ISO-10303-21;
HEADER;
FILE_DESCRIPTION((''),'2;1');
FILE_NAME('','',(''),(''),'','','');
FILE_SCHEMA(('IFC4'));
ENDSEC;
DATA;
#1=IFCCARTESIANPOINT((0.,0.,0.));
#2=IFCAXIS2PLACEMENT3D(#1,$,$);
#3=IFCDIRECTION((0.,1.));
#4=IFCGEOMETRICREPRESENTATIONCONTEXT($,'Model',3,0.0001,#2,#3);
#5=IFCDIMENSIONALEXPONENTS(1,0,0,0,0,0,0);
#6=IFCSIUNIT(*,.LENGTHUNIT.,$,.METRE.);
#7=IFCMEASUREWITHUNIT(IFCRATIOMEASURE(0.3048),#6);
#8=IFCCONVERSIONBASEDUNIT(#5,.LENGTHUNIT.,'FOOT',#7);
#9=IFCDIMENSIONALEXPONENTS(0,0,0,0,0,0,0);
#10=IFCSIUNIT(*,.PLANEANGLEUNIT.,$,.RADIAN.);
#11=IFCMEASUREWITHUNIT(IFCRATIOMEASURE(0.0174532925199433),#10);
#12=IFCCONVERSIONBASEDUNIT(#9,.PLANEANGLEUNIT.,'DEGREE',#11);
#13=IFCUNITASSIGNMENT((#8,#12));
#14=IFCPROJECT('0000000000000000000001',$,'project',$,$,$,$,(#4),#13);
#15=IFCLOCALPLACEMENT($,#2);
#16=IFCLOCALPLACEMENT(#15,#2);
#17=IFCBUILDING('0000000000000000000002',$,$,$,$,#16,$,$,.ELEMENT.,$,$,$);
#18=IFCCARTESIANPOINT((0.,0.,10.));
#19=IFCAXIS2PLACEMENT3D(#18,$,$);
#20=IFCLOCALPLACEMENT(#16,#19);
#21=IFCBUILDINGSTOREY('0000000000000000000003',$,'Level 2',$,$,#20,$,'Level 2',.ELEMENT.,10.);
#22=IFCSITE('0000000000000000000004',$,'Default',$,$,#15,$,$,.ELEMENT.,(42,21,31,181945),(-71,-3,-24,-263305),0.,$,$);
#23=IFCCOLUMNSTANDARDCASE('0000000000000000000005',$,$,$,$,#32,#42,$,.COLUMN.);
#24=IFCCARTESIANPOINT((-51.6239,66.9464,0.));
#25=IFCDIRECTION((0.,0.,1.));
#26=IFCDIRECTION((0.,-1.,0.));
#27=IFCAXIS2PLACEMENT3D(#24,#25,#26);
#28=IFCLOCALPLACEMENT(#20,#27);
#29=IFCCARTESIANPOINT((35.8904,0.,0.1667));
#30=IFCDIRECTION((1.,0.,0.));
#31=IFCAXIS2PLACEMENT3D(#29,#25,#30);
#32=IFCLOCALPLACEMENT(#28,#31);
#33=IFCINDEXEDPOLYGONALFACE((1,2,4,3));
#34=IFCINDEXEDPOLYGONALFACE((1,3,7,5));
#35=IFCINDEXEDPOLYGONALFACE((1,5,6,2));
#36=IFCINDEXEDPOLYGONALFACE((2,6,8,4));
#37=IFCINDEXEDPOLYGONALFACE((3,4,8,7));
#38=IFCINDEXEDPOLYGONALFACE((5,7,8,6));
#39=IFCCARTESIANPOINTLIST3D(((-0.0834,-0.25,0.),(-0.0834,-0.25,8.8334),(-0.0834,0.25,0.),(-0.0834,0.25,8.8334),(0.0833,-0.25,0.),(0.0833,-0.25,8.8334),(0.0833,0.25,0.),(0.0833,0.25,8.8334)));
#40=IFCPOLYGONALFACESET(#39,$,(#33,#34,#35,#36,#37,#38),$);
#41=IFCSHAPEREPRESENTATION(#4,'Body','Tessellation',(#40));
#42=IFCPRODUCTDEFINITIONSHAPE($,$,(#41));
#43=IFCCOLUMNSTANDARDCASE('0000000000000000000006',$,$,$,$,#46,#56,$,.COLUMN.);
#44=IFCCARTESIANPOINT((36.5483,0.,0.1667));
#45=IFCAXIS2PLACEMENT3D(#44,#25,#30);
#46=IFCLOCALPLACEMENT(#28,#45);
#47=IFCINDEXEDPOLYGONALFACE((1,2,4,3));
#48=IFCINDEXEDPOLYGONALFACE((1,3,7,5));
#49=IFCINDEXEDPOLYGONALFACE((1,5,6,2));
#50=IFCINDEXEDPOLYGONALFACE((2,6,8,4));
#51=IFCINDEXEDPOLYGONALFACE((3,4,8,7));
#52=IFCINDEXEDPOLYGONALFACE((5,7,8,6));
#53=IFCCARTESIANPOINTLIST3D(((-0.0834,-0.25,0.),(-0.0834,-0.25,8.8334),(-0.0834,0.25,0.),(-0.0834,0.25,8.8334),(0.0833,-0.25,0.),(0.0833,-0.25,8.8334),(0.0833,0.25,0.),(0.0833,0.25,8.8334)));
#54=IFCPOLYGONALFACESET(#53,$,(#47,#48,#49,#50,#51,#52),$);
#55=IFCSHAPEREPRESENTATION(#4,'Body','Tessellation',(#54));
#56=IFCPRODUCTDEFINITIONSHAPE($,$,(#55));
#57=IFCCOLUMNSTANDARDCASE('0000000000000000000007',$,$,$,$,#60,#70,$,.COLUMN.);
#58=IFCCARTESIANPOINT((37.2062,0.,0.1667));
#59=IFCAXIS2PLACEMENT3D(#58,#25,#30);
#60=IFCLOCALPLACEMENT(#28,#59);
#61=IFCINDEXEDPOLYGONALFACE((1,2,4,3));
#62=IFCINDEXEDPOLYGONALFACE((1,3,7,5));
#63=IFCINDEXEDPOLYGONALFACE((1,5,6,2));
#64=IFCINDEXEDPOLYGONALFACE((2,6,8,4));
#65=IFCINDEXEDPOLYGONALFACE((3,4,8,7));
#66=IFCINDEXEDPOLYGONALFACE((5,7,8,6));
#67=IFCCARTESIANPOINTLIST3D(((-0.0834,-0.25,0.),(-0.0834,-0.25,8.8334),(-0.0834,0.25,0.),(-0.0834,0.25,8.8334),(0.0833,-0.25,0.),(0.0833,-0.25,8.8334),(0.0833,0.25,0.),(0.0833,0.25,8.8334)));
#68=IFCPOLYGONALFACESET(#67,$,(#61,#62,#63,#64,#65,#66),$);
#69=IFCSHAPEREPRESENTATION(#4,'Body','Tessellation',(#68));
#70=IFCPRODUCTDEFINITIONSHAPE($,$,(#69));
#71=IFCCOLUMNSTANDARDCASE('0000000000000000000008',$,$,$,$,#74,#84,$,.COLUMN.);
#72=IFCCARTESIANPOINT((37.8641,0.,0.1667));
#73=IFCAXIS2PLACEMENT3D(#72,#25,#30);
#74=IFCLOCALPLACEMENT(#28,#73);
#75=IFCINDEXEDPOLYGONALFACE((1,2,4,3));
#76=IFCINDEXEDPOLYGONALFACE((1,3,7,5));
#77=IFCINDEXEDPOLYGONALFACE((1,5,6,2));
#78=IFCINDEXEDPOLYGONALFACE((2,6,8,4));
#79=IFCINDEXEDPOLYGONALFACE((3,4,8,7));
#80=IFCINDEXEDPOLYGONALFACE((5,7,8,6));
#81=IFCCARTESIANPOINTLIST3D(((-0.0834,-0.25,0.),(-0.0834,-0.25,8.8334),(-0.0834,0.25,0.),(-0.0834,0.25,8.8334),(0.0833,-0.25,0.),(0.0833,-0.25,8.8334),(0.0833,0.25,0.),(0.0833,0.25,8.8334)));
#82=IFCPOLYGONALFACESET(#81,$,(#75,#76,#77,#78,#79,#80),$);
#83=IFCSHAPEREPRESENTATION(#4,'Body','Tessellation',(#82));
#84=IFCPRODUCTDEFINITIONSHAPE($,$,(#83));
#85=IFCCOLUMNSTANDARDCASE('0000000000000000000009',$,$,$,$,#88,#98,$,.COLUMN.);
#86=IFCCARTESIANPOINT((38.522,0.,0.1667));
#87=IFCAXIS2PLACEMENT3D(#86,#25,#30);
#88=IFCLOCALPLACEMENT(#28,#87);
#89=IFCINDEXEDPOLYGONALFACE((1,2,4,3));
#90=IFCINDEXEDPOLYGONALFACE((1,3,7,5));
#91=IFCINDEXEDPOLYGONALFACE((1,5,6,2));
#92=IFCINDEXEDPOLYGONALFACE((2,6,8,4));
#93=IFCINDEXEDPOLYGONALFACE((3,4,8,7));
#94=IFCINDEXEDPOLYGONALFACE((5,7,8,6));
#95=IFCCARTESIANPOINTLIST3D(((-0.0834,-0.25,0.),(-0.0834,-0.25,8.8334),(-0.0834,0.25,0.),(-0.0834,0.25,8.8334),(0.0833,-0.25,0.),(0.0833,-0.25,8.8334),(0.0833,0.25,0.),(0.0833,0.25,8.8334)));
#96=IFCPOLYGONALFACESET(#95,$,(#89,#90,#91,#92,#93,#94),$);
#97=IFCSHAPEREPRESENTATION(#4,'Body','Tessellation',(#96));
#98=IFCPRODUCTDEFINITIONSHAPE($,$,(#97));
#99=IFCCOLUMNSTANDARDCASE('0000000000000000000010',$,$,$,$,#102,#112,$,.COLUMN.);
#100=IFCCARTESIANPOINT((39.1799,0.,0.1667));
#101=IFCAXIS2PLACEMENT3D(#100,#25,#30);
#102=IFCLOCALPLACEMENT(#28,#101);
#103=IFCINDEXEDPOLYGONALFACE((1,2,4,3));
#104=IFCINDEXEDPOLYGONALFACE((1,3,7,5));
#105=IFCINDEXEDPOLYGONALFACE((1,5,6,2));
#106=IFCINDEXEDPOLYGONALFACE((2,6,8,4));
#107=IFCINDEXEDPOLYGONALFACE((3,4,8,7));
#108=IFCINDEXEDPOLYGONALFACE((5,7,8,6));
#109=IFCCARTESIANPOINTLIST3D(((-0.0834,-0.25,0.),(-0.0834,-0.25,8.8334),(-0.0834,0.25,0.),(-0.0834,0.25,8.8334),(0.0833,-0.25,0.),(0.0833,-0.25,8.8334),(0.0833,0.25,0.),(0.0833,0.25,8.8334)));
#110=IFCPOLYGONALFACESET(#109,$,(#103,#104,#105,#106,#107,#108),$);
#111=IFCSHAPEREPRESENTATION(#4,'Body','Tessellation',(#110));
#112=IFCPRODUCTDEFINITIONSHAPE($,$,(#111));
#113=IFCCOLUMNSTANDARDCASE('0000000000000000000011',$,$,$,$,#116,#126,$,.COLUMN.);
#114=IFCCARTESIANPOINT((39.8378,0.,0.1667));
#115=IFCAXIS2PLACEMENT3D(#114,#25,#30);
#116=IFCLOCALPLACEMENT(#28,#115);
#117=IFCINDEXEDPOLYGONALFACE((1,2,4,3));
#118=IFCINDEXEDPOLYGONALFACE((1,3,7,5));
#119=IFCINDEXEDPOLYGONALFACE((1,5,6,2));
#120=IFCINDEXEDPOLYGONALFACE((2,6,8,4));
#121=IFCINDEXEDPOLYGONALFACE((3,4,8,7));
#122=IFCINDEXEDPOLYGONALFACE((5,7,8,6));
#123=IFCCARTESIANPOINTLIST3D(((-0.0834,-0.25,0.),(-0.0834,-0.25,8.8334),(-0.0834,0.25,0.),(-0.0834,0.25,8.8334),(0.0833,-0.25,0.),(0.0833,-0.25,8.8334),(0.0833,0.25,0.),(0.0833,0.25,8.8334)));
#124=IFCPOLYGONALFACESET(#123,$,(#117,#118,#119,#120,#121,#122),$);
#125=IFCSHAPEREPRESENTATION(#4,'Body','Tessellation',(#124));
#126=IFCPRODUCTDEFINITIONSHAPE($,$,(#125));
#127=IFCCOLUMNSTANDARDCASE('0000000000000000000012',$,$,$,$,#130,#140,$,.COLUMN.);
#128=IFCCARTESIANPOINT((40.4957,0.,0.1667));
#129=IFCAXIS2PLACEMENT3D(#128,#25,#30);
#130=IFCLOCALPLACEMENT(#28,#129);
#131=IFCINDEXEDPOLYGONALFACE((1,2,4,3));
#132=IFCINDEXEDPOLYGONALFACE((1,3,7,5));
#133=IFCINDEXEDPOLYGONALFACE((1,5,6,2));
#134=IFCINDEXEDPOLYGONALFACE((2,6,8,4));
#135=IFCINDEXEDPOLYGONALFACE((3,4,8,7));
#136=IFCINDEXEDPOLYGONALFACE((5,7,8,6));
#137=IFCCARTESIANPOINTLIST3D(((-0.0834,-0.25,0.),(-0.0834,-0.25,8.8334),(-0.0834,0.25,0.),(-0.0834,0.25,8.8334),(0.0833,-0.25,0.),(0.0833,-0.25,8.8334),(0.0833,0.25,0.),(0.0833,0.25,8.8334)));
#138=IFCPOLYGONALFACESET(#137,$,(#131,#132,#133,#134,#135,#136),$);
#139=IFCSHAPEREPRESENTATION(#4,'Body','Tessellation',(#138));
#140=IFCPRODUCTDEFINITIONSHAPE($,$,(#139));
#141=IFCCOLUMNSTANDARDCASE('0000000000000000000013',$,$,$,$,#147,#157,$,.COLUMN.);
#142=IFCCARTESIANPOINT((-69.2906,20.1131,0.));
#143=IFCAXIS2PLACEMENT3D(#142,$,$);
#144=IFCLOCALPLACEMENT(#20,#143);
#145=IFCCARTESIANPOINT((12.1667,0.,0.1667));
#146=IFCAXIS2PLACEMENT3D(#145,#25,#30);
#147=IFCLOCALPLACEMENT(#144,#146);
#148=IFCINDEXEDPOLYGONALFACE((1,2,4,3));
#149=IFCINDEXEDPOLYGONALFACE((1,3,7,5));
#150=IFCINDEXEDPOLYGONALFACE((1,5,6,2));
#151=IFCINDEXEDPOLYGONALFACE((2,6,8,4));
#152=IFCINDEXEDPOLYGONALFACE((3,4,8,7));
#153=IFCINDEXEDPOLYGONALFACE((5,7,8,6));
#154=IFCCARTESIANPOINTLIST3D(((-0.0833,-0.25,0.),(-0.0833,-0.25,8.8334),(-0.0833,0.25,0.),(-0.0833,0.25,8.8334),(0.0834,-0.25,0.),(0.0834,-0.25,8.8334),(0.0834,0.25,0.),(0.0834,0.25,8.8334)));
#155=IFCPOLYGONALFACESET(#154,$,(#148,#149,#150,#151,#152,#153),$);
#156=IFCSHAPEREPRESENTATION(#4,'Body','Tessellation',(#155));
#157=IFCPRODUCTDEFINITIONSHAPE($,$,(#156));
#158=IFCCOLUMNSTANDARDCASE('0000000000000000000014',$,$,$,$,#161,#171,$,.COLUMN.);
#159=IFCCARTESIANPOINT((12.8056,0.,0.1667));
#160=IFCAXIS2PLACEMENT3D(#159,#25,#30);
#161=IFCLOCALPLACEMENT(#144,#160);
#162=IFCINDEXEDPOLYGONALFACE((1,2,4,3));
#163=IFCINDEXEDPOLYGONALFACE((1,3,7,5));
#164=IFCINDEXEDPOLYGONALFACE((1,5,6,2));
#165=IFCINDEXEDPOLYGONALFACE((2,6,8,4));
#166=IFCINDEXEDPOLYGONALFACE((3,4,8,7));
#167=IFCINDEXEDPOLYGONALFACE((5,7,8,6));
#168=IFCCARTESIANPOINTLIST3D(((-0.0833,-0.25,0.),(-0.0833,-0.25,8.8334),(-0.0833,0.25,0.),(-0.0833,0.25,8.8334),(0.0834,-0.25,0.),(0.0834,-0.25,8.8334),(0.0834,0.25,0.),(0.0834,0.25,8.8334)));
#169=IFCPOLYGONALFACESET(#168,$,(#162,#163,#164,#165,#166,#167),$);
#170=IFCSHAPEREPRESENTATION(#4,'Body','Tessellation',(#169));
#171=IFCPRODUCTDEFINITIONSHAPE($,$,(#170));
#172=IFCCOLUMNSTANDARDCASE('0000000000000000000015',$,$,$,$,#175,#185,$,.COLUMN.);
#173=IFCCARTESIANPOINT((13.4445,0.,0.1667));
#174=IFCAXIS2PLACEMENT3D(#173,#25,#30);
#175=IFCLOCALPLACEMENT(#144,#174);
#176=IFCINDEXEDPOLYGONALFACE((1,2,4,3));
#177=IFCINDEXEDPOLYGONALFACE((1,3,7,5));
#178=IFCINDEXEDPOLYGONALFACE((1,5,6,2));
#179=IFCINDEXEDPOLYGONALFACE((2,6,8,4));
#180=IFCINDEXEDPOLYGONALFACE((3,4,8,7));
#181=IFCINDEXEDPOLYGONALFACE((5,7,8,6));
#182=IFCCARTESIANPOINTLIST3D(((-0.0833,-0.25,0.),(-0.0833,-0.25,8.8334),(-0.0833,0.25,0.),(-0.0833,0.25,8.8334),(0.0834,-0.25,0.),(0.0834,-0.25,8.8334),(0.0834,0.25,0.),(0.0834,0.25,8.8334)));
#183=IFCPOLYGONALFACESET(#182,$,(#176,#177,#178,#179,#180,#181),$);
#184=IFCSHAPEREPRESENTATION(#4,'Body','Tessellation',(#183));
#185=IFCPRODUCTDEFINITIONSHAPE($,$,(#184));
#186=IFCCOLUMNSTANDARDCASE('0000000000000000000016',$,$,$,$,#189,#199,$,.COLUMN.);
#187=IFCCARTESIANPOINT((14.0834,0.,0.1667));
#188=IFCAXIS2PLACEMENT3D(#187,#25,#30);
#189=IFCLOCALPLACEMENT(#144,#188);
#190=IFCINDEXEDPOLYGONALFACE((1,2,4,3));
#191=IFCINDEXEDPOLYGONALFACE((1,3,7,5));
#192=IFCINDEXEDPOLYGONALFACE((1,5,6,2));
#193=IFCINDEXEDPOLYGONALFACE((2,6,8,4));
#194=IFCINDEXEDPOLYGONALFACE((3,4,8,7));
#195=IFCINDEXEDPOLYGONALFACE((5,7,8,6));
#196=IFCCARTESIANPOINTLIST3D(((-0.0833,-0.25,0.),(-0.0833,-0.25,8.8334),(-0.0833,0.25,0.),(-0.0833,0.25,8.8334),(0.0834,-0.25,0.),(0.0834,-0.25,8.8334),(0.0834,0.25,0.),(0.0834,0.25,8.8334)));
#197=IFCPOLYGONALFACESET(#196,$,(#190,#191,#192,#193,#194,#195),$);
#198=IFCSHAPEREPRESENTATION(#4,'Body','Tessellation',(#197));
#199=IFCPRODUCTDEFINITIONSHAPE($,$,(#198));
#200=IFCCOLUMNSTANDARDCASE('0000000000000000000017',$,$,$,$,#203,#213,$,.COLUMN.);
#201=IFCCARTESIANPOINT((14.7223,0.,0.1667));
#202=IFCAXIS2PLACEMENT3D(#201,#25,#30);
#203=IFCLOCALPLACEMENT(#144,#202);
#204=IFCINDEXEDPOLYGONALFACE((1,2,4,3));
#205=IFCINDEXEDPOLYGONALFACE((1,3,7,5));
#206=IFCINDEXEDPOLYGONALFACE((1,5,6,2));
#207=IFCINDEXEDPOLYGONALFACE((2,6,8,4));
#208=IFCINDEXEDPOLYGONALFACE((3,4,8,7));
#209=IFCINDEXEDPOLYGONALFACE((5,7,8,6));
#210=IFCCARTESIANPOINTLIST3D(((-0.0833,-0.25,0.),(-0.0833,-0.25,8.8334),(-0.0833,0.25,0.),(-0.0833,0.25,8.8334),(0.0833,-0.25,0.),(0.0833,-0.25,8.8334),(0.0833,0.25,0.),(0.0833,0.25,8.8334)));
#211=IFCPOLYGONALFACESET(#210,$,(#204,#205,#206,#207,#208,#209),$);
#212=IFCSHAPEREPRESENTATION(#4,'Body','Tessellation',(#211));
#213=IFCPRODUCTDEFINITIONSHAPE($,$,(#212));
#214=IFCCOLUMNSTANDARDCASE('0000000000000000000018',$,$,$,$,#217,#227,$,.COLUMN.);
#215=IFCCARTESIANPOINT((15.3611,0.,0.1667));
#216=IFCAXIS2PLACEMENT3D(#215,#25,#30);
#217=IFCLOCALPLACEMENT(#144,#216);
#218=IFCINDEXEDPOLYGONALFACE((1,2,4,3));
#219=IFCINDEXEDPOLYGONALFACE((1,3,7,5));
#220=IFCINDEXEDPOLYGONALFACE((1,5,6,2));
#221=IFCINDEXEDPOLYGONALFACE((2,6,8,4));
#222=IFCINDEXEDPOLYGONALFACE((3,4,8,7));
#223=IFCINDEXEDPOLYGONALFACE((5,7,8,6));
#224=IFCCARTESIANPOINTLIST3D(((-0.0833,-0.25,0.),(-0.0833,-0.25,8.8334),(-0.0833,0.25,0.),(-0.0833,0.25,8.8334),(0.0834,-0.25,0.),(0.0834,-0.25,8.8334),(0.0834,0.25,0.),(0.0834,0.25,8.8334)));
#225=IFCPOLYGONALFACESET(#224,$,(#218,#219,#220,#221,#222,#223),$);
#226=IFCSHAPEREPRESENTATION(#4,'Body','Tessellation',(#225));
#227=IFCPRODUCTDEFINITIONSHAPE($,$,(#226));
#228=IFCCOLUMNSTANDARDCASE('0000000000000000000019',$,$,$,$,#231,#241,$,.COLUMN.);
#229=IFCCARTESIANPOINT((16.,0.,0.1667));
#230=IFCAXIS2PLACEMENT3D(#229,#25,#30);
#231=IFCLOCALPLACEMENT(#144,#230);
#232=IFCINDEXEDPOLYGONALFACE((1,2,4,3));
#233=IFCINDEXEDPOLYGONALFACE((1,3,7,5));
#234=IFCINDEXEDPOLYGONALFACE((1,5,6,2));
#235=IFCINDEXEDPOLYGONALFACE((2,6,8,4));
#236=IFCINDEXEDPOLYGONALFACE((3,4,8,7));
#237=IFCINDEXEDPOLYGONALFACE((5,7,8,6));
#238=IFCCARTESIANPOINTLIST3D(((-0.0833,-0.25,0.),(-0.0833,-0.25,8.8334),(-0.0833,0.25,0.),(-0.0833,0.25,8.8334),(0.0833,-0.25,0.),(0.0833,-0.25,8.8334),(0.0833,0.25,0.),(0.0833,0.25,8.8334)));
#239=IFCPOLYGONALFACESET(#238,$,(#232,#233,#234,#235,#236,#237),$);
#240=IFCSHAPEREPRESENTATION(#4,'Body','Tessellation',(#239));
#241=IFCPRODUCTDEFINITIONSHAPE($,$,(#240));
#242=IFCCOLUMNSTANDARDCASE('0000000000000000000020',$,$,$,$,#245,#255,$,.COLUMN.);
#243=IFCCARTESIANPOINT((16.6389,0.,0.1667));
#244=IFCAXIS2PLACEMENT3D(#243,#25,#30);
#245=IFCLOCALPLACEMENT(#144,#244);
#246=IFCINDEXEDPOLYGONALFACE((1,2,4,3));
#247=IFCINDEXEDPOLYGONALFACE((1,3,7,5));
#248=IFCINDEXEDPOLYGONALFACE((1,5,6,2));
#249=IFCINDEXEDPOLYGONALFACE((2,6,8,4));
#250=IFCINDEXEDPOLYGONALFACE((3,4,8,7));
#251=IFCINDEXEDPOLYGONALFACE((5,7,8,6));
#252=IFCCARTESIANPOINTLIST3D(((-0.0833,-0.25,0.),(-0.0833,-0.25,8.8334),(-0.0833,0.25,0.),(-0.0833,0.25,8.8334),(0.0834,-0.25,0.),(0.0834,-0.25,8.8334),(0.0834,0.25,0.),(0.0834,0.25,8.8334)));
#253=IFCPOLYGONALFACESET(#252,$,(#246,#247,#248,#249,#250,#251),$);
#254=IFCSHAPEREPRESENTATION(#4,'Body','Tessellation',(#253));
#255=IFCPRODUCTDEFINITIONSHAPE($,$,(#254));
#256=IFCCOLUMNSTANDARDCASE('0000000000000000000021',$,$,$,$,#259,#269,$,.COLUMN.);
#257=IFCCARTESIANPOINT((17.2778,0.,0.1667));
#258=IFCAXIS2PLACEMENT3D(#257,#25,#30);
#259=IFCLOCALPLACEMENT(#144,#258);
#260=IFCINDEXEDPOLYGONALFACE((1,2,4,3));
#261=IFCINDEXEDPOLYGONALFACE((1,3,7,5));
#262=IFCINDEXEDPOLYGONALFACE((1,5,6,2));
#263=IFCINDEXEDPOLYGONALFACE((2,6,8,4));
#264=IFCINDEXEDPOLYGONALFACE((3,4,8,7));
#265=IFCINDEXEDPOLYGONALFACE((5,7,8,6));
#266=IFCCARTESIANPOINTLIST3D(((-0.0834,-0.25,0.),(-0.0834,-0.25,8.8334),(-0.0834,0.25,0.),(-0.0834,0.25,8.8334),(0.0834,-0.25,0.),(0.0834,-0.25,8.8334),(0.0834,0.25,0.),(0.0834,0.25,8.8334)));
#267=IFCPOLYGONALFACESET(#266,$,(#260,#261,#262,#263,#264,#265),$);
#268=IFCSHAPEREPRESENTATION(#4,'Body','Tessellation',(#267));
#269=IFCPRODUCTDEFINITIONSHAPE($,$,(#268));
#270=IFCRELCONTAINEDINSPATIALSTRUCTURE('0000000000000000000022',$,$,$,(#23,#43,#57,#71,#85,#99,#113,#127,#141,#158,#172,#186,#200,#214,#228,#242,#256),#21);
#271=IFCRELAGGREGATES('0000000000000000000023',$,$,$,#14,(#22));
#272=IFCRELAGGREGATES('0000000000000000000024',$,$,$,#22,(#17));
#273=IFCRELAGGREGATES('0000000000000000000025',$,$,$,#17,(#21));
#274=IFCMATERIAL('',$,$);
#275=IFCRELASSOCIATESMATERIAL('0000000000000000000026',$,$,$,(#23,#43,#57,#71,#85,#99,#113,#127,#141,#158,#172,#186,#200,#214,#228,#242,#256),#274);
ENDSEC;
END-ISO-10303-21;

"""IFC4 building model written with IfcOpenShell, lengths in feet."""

from ifc_helpers import new_model, entity, si_unit, converted_unit, direction, frame, origin, place, context, project, spatial, rectangle, extrude, material, element, save


model = new_model("IFC4")

# Units and contexts
model_context = context("Model", 3, precision=0.0001, world=origin(), true_north=direction((0.0, 1.0)))
ifc_project = project(units=[converted_unit("LENGTHUNIT", "FOOT", entity("IfcRatioMeasure", 0.3048), si_unit("LENGTHUNIT", "METRE"), dimensions=[1, 0, 0, 0, 0, 0, 0]), converted_unit("PLANEANGLEUNIT", "DEGREE", entity("IfcRatioMeasure", 0.0174532925199433), si_unit("PLANEANGLEUNIT", "RADIAN"), dimensions=[0, 0, 0, 0, 0, 0, 0])], contexts=[model_context])

# Site, building, storey
site_placement = place(None, origin())
site = spatial("IfcSite", under=ifc_project, at=site_placement, Name="Default", CompositionType="ELEMENT", RefLatitude=(42, 21, 31, 181945), RefLongitude=(-71, -3, -24, -263305), RefElevation=0.0)
building_placement = place(site_placement, origin())
building = spatial("IfcBuilding", under=site, at=building_placement, CompositionType="ELEMENT")
storey_placement = place(building_placement, frame((0.0, 0.0, 10.0)))
storey = spatial("IfcBuildingStorey", under=building, at=storey_placement, Name="Level 2", LongName="Level 2", CompositionType="ELEMENT", Elevation=10.0)

# Columns
ifc_material_1 = material(Name="")
placement_1 = place(storey_placement, frame((-51.6239, 66.9464, 0.0), z_axis=(0.0, 0.0, 1.0), x_axis=(0.0, -1.0, 0.0)))
for number, where, z_axis, x_axis in (
    (1, (35.8904, 0.0, 0.1667), (0.0, 0.0, 1.0), (1.0, 0.0, 0.0)),
    (2, (36.5483, 0.0, 0.1667), (0.0, 0.0, 1.0), (1.0, 0.0, 0.0)),
    (3, (37.2062, 0.0, 0.1667), (0.0, 0.0, 1.0), (1.0, 0.0, 0.0)),
    (4, (37.8641, 0.0, 0.1667), (0.0, 0.0, 1.0), (1.0, 0.0, 0.0)),
    (5, (38.522, 0.0, 0.1667), (0.0, 0.0, 1.0), (1.0, 0.0, 0.0)),
    (6, (39.1799, 0.0, 0.1667), (0.0, 0.0, 1.0), (1.0, 0.0, 0.0)),
    (7, (39.8378, 0.0, 0.1667), (0.0, 0.0, 1.0), (1.0, 0.0, 0.0)),
    (8, (40.4957, 0.0, 0.1667), (0.0, 0.0, 1.0), (1.0, 0.0, 0.0)),
):
    element("IfcColumnStandardCase", number, at=place(placement_1, frame(where, z_axis=z_axis, x_axis=x_axis)), inside=storey, material=ifc_material_1, PredefinedType="COLUMN", context=model_context, shape_type="SweptSolid", body=[
        extrude(rectangle(XDim=0.1667, YDim=0.5), origin(), (0.0, 0.0, 1.0), 8.8334),
    ])
placement_2 = place(storey_placement, frame((-69.2906, 20.1131, 0.0)))
for number, where, z_axis, x_axis in (
    (9, (12.1667, 0.0, 0.1667), (0.0, 0.0, 1.0), (1.0, 0.0, 0.0)),
    (10, (12.8056, 0.0, 0.1667), (0.0, 0.0, 1.0), (1.0, 0.0, 0.0)),
    (11, (13.4445, 0.0, 0.1667), (0.0, 0.0, 1.0), (1.0, 0.0, 0.0)),
    (12, (14.0834, 0.0, 0.1667), (0.0, 0.0, 1.0), (1.0, 0.0, 0.0)),
    (13, (14.7223, 0.0, 0.1667), (0.0, 0.0, 1.0), (1.0, 0.0, 0.0)),
    (14, (15.3611, 0.0, 0.1667), (0.0, 0.0, 1.0), (1.0, 0.0, 0.0)),
    (15, (16.0, 0.0, 0.1667), (0.0, 0.0, 1.0), (1.0, 0.0, 0.0)),
    (16, (16.6389, 0.0, 0.1667), (0.0, 0.0, 1.0), (1.0, 0.0, 0.0)),
    (17, (17.2778, 0.0, 0.1667), (0.0, 0.0, 1.0), (1.0, 0.0, 0.0)),
):
    element("IfcColumnStandardCase", number, at=place(placement_2, frame(where, z_axis=z_axis, x_axis=x_axis)), inside=storey, material=ifc_material_1, PredefinedType="COLUMN", context=model_context, shape_type="SweptSolid", body=[
        extrude(rectangle(XDim=0.1667, YDim=0.5), origin(), (0.0, 0.0, 1.0), 8.8334),
    ])

save(model, "model.ifc")
